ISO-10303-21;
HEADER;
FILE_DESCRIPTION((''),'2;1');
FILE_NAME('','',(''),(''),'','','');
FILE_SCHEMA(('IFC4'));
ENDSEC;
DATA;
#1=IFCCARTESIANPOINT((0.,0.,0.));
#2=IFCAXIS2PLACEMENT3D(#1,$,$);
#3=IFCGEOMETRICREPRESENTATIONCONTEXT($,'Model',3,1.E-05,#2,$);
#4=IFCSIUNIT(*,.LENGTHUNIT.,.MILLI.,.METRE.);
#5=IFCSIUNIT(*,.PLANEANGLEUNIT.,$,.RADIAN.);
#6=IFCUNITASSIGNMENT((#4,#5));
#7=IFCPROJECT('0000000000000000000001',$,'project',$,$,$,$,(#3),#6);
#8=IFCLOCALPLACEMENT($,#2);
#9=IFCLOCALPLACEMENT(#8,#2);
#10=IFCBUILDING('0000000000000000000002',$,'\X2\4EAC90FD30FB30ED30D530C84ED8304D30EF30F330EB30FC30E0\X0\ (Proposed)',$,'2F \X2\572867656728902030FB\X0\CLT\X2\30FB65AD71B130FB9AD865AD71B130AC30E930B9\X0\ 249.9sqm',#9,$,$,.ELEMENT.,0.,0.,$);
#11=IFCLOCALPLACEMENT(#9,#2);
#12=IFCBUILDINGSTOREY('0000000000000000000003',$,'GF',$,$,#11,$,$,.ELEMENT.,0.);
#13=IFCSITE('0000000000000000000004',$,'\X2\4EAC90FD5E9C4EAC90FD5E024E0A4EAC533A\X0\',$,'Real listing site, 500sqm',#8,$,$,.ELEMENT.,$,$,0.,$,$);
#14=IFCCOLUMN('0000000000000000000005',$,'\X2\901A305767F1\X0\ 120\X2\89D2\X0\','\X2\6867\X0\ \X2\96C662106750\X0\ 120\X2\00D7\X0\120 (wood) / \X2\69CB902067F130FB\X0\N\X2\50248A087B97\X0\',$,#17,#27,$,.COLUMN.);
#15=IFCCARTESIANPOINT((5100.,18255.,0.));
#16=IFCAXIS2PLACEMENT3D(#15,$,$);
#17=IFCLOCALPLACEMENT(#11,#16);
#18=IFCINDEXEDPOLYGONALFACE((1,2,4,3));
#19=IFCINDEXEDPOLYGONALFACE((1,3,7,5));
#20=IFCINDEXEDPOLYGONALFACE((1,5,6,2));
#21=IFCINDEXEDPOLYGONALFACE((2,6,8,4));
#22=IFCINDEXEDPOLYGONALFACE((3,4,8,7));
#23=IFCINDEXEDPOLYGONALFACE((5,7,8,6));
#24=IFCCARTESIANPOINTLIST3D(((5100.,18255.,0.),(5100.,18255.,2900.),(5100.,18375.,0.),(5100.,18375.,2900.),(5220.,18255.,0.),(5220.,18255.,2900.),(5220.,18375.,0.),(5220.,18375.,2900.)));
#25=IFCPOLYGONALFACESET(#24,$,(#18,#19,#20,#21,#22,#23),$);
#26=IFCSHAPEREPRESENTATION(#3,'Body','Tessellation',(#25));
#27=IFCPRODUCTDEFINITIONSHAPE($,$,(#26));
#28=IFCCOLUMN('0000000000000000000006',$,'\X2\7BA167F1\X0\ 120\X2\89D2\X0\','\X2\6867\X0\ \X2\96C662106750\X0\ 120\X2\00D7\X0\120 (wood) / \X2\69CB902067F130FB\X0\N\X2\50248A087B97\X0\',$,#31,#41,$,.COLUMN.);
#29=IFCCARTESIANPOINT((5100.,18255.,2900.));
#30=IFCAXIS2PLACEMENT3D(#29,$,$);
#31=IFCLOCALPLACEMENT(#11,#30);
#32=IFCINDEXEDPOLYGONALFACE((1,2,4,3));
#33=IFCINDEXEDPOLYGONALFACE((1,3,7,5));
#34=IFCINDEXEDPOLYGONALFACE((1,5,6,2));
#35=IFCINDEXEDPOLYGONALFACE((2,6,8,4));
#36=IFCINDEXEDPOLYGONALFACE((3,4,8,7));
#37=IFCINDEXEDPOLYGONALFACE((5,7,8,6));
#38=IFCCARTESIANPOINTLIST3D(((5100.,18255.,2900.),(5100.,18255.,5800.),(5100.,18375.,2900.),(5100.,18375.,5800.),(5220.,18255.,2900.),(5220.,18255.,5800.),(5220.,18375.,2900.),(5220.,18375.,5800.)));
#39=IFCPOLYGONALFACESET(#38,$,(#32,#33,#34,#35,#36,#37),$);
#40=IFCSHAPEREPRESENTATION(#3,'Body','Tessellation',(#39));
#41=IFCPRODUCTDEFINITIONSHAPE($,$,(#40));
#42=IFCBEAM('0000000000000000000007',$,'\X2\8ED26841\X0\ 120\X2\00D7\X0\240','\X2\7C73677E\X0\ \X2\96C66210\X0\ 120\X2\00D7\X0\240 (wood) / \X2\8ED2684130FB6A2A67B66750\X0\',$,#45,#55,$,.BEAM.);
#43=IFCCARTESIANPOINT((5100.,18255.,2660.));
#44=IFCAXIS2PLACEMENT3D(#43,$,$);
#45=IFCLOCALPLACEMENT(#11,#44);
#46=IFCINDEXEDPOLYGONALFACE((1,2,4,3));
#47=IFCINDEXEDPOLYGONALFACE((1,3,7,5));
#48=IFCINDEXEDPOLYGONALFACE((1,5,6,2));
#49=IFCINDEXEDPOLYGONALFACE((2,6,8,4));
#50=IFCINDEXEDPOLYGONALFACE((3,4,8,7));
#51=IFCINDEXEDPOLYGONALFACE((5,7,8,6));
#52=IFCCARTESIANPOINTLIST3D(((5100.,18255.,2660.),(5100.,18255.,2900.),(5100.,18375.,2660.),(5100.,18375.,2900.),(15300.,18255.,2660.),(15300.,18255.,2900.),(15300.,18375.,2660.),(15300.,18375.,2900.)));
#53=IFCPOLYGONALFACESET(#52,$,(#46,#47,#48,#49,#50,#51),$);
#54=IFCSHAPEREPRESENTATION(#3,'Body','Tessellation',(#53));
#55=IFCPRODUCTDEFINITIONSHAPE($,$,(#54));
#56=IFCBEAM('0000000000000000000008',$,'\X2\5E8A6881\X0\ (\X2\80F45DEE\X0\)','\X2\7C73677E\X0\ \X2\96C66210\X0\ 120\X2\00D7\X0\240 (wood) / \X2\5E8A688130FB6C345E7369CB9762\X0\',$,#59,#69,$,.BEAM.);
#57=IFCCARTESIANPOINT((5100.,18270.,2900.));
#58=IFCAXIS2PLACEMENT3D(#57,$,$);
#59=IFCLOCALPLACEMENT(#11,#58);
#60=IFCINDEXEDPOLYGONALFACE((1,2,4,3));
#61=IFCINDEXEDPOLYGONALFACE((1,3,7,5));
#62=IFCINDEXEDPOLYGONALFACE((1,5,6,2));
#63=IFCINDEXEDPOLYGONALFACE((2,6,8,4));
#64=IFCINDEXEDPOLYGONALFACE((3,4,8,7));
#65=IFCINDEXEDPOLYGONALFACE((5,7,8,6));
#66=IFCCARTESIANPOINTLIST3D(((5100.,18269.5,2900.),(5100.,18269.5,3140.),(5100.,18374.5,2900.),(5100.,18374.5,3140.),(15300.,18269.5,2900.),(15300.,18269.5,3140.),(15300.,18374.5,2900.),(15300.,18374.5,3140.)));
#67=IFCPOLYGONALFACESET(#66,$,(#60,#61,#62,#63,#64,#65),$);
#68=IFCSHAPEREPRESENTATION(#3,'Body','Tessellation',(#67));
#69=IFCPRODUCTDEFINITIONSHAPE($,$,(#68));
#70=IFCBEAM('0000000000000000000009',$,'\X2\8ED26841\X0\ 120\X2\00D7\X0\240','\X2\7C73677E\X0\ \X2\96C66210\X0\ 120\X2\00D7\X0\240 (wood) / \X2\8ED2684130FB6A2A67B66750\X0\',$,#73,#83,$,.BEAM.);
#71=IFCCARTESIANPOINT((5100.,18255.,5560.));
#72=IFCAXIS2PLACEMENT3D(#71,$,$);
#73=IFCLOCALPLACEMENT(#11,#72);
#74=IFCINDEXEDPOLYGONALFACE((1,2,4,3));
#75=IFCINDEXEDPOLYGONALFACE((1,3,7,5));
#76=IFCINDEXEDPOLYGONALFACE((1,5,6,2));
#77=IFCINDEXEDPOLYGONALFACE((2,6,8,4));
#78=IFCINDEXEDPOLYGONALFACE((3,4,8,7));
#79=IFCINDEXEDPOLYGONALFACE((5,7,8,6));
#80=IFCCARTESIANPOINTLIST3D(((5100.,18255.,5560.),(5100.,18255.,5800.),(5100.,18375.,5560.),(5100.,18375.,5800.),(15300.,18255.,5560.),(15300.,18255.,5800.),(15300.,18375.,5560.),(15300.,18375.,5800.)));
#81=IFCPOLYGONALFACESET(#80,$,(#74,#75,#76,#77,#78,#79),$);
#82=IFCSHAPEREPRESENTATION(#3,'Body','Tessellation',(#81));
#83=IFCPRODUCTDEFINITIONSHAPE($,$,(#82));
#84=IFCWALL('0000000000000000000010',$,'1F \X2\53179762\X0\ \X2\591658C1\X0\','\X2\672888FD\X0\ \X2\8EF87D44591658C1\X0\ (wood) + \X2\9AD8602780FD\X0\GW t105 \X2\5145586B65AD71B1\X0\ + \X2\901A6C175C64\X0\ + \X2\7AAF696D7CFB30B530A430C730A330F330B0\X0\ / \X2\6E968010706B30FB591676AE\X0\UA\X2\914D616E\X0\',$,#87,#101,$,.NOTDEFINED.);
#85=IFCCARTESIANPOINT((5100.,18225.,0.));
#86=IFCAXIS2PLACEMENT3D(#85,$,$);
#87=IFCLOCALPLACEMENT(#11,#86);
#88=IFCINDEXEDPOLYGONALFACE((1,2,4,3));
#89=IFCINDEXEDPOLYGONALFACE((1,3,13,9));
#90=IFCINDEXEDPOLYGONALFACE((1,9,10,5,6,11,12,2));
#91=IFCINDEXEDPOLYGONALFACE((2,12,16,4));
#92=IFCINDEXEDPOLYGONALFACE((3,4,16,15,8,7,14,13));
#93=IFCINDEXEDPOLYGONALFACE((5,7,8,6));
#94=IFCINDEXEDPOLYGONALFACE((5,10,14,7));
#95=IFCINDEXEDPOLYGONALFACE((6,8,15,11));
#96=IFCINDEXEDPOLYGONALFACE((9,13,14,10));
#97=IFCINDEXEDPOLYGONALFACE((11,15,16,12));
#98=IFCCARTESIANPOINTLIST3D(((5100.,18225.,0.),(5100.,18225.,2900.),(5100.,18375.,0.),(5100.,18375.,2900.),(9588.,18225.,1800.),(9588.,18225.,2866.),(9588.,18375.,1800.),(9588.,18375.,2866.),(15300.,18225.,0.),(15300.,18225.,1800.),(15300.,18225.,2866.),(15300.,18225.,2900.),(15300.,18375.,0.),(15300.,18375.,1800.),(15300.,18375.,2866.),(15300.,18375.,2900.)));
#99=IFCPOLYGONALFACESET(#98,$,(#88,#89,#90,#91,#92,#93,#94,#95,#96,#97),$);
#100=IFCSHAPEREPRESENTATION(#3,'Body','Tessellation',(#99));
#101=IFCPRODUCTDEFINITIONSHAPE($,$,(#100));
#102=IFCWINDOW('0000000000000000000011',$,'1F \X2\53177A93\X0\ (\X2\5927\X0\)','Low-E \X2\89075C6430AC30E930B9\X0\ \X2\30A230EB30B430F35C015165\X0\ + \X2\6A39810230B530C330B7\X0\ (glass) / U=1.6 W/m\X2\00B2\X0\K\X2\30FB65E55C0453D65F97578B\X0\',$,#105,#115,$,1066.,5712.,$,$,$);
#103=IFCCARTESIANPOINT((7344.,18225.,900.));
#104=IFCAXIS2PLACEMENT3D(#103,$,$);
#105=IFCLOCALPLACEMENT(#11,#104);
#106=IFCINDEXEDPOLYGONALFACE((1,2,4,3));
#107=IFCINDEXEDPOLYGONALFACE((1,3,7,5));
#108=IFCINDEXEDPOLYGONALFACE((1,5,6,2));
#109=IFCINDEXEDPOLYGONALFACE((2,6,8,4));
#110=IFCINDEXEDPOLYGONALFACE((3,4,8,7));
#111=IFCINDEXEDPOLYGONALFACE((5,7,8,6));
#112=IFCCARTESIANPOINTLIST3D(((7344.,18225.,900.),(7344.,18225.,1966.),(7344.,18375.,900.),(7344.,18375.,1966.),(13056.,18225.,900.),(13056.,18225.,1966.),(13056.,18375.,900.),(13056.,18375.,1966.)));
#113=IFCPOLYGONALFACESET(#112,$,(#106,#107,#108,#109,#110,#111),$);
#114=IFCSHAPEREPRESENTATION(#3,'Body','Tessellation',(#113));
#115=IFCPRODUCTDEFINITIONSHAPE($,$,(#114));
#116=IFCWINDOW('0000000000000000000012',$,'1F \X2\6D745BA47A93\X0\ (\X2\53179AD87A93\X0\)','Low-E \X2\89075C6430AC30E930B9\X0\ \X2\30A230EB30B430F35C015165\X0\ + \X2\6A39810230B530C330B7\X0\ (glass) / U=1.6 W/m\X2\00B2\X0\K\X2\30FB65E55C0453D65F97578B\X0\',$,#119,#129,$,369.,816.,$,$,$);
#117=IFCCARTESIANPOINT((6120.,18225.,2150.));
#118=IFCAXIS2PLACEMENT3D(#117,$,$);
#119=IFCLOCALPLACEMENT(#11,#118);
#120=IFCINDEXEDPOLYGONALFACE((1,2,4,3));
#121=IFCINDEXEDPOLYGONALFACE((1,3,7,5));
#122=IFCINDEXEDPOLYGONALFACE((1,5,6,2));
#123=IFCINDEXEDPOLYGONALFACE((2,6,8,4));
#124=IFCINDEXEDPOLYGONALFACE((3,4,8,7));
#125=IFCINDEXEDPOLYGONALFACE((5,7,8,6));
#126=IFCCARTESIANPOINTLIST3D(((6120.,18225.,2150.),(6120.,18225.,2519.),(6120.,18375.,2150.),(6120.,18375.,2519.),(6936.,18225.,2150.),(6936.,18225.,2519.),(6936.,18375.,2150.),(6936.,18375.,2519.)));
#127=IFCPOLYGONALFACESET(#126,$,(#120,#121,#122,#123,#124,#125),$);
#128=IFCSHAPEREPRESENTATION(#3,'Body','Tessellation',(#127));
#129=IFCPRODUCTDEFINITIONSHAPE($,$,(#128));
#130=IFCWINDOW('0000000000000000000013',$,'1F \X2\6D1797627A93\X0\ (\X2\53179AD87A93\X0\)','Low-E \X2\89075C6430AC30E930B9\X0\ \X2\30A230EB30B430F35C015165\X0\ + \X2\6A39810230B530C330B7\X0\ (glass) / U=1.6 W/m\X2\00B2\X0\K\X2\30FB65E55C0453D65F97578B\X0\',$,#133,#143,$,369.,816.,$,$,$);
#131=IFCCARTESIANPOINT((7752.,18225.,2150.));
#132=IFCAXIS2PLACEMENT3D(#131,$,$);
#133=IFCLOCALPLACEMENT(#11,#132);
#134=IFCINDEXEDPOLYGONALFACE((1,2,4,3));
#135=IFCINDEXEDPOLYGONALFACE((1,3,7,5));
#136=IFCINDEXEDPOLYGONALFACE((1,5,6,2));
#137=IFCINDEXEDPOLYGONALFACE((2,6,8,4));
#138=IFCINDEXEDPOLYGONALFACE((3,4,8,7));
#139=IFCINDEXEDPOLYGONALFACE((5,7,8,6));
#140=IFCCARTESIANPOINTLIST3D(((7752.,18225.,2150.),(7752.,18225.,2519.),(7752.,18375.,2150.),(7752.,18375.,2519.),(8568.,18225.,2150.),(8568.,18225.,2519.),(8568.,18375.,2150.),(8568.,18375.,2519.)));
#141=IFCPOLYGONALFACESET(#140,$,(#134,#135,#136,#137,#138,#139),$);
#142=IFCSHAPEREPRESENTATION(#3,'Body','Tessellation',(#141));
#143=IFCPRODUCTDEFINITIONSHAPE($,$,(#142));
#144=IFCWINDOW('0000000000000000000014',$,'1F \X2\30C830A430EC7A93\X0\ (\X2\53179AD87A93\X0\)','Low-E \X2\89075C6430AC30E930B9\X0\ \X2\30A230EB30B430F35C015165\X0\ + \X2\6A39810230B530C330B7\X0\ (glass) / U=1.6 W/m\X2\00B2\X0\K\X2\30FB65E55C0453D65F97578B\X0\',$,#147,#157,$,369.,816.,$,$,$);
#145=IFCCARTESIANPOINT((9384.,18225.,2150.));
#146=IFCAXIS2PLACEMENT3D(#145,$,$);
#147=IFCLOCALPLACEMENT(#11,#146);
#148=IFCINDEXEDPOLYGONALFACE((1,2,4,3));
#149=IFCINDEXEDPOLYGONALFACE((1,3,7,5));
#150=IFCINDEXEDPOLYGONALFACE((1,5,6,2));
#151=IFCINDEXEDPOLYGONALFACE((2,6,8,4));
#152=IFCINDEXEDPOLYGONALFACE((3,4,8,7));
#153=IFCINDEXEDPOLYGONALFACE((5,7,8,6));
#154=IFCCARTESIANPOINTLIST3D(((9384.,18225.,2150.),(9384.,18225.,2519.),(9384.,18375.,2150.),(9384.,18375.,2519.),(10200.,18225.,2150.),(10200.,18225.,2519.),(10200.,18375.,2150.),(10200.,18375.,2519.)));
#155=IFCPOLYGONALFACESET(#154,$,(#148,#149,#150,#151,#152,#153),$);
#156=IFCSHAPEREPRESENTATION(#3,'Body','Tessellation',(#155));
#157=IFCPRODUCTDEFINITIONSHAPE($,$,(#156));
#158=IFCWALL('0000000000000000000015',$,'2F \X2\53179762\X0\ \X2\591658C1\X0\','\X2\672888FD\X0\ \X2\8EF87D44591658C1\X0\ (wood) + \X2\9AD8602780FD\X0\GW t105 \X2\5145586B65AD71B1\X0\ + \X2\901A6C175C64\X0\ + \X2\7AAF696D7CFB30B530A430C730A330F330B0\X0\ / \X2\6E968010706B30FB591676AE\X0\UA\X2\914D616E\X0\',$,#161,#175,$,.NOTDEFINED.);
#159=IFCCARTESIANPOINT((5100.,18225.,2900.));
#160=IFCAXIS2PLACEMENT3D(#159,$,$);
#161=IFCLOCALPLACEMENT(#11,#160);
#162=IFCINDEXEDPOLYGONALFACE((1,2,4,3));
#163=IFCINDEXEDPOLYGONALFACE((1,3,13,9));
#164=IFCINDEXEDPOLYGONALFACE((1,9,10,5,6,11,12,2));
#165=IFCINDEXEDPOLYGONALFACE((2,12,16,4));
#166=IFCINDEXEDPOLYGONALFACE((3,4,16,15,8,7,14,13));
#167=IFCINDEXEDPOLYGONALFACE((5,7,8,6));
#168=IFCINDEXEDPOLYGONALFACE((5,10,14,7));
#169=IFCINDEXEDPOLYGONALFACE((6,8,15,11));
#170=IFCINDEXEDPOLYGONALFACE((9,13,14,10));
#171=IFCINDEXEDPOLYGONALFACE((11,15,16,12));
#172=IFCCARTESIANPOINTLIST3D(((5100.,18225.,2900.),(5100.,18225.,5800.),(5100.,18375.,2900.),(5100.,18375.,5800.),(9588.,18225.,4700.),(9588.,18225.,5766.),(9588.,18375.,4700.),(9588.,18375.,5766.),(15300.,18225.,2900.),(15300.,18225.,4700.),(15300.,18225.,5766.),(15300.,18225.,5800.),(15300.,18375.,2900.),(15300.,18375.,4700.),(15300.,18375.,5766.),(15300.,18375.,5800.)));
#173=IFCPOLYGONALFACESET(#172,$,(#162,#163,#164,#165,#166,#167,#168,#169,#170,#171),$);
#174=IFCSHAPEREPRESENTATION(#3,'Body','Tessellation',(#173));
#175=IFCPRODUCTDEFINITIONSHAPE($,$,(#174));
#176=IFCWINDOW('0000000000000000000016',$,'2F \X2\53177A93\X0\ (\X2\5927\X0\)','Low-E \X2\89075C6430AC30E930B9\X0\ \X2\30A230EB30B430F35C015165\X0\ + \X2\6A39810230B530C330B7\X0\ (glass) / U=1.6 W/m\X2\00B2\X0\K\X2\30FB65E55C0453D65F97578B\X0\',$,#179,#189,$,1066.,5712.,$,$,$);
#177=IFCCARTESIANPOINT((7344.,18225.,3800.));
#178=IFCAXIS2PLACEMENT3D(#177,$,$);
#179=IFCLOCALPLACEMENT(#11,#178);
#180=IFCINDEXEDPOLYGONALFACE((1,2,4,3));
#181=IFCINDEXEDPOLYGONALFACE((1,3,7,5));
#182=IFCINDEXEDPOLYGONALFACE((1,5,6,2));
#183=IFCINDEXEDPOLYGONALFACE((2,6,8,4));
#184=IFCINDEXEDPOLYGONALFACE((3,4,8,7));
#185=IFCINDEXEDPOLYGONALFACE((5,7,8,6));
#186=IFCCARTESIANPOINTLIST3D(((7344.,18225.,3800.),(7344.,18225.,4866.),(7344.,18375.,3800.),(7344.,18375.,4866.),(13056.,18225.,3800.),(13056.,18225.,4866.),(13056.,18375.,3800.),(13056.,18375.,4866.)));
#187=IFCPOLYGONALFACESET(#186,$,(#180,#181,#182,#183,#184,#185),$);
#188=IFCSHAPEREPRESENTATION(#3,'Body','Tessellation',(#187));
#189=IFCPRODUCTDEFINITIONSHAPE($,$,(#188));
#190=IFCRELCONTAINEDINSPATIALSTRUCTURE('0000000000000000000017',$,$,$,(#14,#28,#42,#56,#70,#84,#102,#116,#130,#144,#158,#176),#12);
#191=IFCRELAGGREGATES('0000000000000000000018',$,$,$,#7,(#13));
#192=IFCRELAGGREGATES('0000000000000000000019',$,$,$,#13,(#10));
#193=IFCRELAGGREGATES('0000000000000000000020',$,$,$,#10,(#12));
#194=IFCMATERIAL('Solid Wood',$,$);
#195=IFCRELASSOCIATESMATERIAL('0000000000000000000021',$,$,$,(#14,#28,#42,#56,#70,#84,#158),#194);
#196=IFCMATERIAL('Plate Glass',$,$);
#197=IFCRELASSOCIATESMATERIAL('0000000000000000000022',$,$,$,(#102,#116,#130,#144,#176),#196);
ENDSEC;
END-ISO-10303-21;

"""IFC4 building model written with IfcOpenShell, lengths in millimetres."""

from ifc_helpers import new_model, si_unit, frame, frame_2d, origin, place, context, project, spatial, rectangle, extrude, material, element, fill, save


model = new_model("IFC4")

# Units and contexts
model_context = context("Model", 3, precision=1e-05, world=origin())
ifc_project = project(units=[si_unit("LENGTHUNIT", "METRE", prefix="MILLI"), si_unit("PLANEANGLEUNIT", "RADIAN")], contexts=[model_context])

# Site, building, storey
site_placement = place(None, origin())
site = spatial("IfcSite", under=ifc_project, at=site_placement, Name="京都府京都市上京区", ObjectType="Real listing site, 500sqm", CompositionType="ELEMENT", RefElevation=0.0)
building_placement = place(site_placement, origin())
building = spatial("IfcBuilding", under=site, at=building_placement, Name="京都・ロフト付きワンルーム (Proposed)", ObjectType="2F 在来木造・CLT・断熱・高断熱ガラス 249.9sqm", CompositionType="ELEMENT", ElevationOfRefHeight=0.0, ElevationOfTerrain=0.0)
storey_placement = place(building_placement, origin())
storey = spatial("IfcBuildingStorey", under=building, at=storey_placement, Name="GF", CompositionType="ELEMENT", Elevation=0.0)

# Columns
ifc_material_1 = material(Name="Solid Wood")
column_1_placement = place(storey_placement, frame((5100.0, 18255.0, 0.0)))
element("IfcColumn", 1, at=column_1_placement, inside=storey, material=ifc_material_1, Name="通し柱 120角", Description="桧 集成材 120×120 (wood) / 構造柱・N値計算", PredefinedType="COLUMN", context=model_context, shape_type="SweptSolid", body=[
    extrude(rectangle(XDim=120.0, YDim=120.0, at=frame_2d((60.0, 60.0))), frame((5100.0, 18255.0, 0.0)), (0.0, 0.0, 1.0), 2900.0),
])
column_2_placement = place(storey_placement, frame((5100.0, 18255.0, 2900.0)))
element("IfcColumn", 2, at=column_2_placement, inside=storey, material=ifc_material_1, Name="管柱 120角", Description="桧 集成材 120×120 (wood) / 構造柱・N値計算", PredefinedType="COLUMN", context=model_context, shape_type="SweptSolid", body=[
    extrude(rectangle(XDim=120.0, YDim=120.0, at=frame_2d((60.0, 60.0))), frame((5100.0, 18255.0, 2900.0)), (0.0, 0.0, 1.0), 2900.0),
])

# Beams
beam_1_placement = place(storey_placement, frame((5100.0, 18255.0, 2660.0)))
element("IfcBeam", 3, at=beam_1_placement, inside=storey, material=ifc_material_1, Name="軒桁 120×240", Description="米松 集成 120×240 (wood) / 軒桁・横架材", PredefinedType="BEAM", context=model_context, shape_type="SweptSolid", body=[
    extrude(rectangle(XDim=10200.0, YDim=120.0, at=frame_2d((5100.0, 60.0))), frame((5100.0, 18255.0, 2660.0)), (0.0, 0.0, 1.0), 240.0),
])
beam_2_placement = place(storey_placement, frame((5100.0, 18270.0, 2900.0)))
element("IfcBeam", 4, at=beam_2_placement, inside=storey, material=ifc_material_1, Name="床梁 (胴差)", Description="米松 集成 120×240 (wood) / 床梁・水平構面", PredefinedType="BEAM", context=model_context, shape_type="SweptSolid", body=[
    extrude(rectangle(XDim=10200.0, YDim=105.0, at=frame_2d((5100.0, 52.0))), frame((5100.0, 18270.0, 2900.0)), (0.0, 0.0, 1.0), 240.0),
])
beam_3_placement = place(storey_placement, frame((5100.0, 18255.0, 5560.0)))
element("IfcBeam", 5, at=beam_3_placement, inside=storey, material=ifc_material_1, Name="軒桁 120×240", Description="米松 集成 120×240 (wood) / 軒桁・横架材", PredefinedType="BEAM", context=model_context, shape_type="SweptSolid", body=[
    extrude(rectangle(XDim=10200.0, YDim=120.0, at=frame_2d((5100.0, 60.0))), frame((5100.0, 18255.0, 5560.0)), (0.0, 0.0, 1.0), 240.0),
])

# Wall, openings, windows
wall_1_placement = place(storey_placement, frame((5100.0, 18225.0, 0.0)))
wall_1 = element("IfcWall", 6, at=wall_1_placement, inside=storey, material=ifc_material_1, Name="1F 北面 外壁", Description="木製 軸組外壁 (wood) + 高性能GW t105 充填断熱 + 通気層 + 窯業系サイディング / 準耐火・外皮UA配慮", PredefinedType="NOTDEFINED", context=model_context, shape_type="SweptSolid", body=[
    extrude(rectangle(XDim=10200.0, YDim=150.0, at=frame_2d((5100.0, 75.0))), frame((5100.0, 18225.0, 0.0)), (0.0, 0.0, 1.0), 2900.0),
])
opening_1_placement = place(storey_placement, frame((7344.0, 18225.0, 900.0)))
opening_1 = element("IfcOpeningElement", 7, at=opening_1_placement, cuts=wall_1, PredefinedType="NOTDEFINED", context=model_context, shape_type="SweptSolid", body=[
    extrude(rectangle(XDim=5712.0, YDim=150.0, at=frame_2d((2856.0, 75.0))), frame((7344.0, 18225.0, 900.0)), (0.0, 0.0, 1.0), 1066.0),
])
opening_2_placement = place(storey_placement, frame((6120.0, 18225.0, 2150.0)))
opening_2 = element("IfcOpeningElement", 8, at=opening_2_placement, cuts=wall_1, PredefinedType="NOTDEFINED", context=model_context, shape_type="SweptSolid", body=[
    extrude(rectangle(XDim=816.0, YDim=150.0, at=frame_2d((408.0, 75.0))), frame((6120.0, 18225.0, 2150.0)), (0.0, 0.0, 1.0), 369.0),
])
opening_3_placement = place(storey_placement, frame((7752.0, 18225.0, 2150.0)))
opening_3 = element("IfcOpeningElement", 9, at=opening_3_placement, cuts=wall_1, PredefinedType="NOTDEFINED", context=model_context, shape_type="SweptSolid", body=[
    extrude(rectangle(XDim=816.0, YDim=150.0, at=frame_2d((408.0, 75.0))), frame((7752.0, 18225.0, 2150.0)), (0.0, 0.0, 1.0), 369.0),
])
opening_4_placement = place(storey_placement, frame((9384.0, 18225.0, 2150.0)))
opening_4 = element("IfcOpeningElement", 10, at=opening_4_placement, cuts=wall_1, PredefinedType="NOTDEFINED", context=model_context, shape_type="SweptSolid", body=[
    extrude(rectangle(XDim=816.0, YDim=150.0, at=frame_2d((408.0, 75.0))), frame((9384.0, 18225.0, 2150.0)), (0.0, 0.0, 1.0), 369.0),
])
ifc_material_2 = material(Name="Plate Glass")
window_1_placement = place(storey_placement, frame((7344.0, 18225.0, 900.0)))
window_1 = element("IfcWindow", 11, at=window_1_placement, inside=storey, material=ifc_material_2, Name="1F 北窓 (大)", Description="Low-E 複層ガラス アルゴン封入 + 樹脂サッシ (glass) / U=1.6 W/m²K・日射取得型", OverallHeight=1066.0, OverallWidth=5712.0, context=model_context, shape_type="SweptSolid", body=[
    extrude(rectangle(XDim=5712.0, YDim=150.0, at=frame_2d((2856.0, 75.0))), frame((7344.0, 18225.0, 900.0)), (0.0, 0.0, 1.0), 1066.0),
])
fill(opening_1, window_1)
window_2_placement = place(storey_placement, frame((6120.0, 18225.0, 2150.0)))
window_2 = element("IfcWindow", 12, at=window_2_placement, inside=storey, material=ifc_material_2, Name="1F 浴室窓 (北高窓)", Description="Low-E 複層ガラス アルゴン封入 + 樹脂サッシ (glass) / U=1.6 W/m²K・日射取得型", OverallHeight=369.0, OverallWidth=816.0, context=model_context, shape_type="SweptSolid", body=[
    extrude(rectangle(XDim=816.0, YDim=150.0, at=frame_2d((408.0, 75.0))), frame((6120.0, 18225.0, 2150.0)), (0.0, 0.0, 1.0), 369.0),
])
fill(opening_2, window_2)
window_3_placement = place(storey_placement, frame((7752.0, 18225.0, 2150.0)))
window_3 = element("IfcWindow", 13, at=window_3_placement, inside=storey, material=ifc_material_2, Name="1F 洗面窓 (北高窓)", Description="Low-E 複層ガラス アルゴン封入 + 樹脂サッシ (glass) / U=1.6 W/m²K・日射取得型", OverallHeight=369.0, OverallWidth=816.0, context=model_context, shape_type="SweptSolid", body=[
    extrude(rectangle(XDim=816.0, YDim=150.0, at=frame_2d((408.0, 75.0))), frame((7752.0, 18225.0, 2150.0)), (0.0, 0.0, 1.0), 369.0),
])
fill(opening_3, window_3)
window_4_placement = place(storey_placement, frame((9384.0, 18225.0, 2150.0)))
window_4 = element("IfcWindow", 14, at=window_4_placement, inside=storey, material=ifc_material_2, Name="1F トイレ窓 (北高窓)", Description="Low-E 複層ガラス アルゴン封入 + 樹脂サッシ (glass) / U=1.6 W/m²K・日射取得型", OverallHeight=369.0, OverallWidth=816.0, context=model_context, shape_type="SweptSolid", body=[
    extrude(rectangle(XDim=816.0, YDim=150.0, at=frame_2d((408.0, 75.0))), frame((9384.0, 18225.0, 2150.0)), (0.0, 0.0, 1.0), 369.0),
])
fill(opening_4, window_4)

# Wall, opening, window
wall_2_placement = place(storey_placement, frame((5100.0, 18225.0, 2900.0)))
wall_2 = element("IfcWall", 15, at=wall_2_placement, inside=storey, material=ifc_material_1, Name="2F 北面 外壁", Description="木製 軸組外壁 (wood) + 高性能GW t105 充填断熱 + 通気層 + 窯業系サイディング / 準耐火・外皮UA配慮", PredefinedType="NOTDEFINED", context=model_context, shape_type="SweptSolid", body=[
    extrude(rectangle(XDim=10200.0, YDim=150.0, at=frame_2d((5100.0, 75.0))), frame((5100.0, 18225.0, 2900.0)), (0.0, 0.0, 1.0), 2900.0),
])
opening_5_placement = place(storey_placement, frame((7344.0, 18225.0, 3800.0)))
opening_5 = element("IfcOpeningElement", 16, at=opening_5_placement, cuts=wall_2, PredefinedType="NOTDEFINED", context=model_context, shape_type="SweptSolid", body=[
    extrude(rectangle(XDim=5712.0, YDim=150.0, at=frame_2d((2856.0, 75.0))), frame((7344.0, 18225.0, 3800.0)), (0.0, 0.0, 1.0), 1066.0),
])
window_5_placement = place(storey_placement, frame((7344.0, 18225.0, 3800.0)))
window_5 = element("IfcWindow", 17, at=window_5_placement, inside=storey, material=ifc_material_2, Name="2F 北窓 (大)", Description="Low-E 複層ガラス アルゴン封入 + 樹脂サッシ (glass) / U=1.6 W/m²K・日射取得型", OverallHeight=1066.0, OverallWidth=5712.0, context=model_context, shape_type="SweptSolid", body=[
    extrude(rectangle(XDim=5712.0, YDim=150.0, at=frame_2d((2856.0, 75.0))), frame((7344.0, 18225.0, 3800.0)), (0.0, 0.0, 1.0), 1066.0),
])
fill(opening_5, window_5)

save(model, "model.ifc")
